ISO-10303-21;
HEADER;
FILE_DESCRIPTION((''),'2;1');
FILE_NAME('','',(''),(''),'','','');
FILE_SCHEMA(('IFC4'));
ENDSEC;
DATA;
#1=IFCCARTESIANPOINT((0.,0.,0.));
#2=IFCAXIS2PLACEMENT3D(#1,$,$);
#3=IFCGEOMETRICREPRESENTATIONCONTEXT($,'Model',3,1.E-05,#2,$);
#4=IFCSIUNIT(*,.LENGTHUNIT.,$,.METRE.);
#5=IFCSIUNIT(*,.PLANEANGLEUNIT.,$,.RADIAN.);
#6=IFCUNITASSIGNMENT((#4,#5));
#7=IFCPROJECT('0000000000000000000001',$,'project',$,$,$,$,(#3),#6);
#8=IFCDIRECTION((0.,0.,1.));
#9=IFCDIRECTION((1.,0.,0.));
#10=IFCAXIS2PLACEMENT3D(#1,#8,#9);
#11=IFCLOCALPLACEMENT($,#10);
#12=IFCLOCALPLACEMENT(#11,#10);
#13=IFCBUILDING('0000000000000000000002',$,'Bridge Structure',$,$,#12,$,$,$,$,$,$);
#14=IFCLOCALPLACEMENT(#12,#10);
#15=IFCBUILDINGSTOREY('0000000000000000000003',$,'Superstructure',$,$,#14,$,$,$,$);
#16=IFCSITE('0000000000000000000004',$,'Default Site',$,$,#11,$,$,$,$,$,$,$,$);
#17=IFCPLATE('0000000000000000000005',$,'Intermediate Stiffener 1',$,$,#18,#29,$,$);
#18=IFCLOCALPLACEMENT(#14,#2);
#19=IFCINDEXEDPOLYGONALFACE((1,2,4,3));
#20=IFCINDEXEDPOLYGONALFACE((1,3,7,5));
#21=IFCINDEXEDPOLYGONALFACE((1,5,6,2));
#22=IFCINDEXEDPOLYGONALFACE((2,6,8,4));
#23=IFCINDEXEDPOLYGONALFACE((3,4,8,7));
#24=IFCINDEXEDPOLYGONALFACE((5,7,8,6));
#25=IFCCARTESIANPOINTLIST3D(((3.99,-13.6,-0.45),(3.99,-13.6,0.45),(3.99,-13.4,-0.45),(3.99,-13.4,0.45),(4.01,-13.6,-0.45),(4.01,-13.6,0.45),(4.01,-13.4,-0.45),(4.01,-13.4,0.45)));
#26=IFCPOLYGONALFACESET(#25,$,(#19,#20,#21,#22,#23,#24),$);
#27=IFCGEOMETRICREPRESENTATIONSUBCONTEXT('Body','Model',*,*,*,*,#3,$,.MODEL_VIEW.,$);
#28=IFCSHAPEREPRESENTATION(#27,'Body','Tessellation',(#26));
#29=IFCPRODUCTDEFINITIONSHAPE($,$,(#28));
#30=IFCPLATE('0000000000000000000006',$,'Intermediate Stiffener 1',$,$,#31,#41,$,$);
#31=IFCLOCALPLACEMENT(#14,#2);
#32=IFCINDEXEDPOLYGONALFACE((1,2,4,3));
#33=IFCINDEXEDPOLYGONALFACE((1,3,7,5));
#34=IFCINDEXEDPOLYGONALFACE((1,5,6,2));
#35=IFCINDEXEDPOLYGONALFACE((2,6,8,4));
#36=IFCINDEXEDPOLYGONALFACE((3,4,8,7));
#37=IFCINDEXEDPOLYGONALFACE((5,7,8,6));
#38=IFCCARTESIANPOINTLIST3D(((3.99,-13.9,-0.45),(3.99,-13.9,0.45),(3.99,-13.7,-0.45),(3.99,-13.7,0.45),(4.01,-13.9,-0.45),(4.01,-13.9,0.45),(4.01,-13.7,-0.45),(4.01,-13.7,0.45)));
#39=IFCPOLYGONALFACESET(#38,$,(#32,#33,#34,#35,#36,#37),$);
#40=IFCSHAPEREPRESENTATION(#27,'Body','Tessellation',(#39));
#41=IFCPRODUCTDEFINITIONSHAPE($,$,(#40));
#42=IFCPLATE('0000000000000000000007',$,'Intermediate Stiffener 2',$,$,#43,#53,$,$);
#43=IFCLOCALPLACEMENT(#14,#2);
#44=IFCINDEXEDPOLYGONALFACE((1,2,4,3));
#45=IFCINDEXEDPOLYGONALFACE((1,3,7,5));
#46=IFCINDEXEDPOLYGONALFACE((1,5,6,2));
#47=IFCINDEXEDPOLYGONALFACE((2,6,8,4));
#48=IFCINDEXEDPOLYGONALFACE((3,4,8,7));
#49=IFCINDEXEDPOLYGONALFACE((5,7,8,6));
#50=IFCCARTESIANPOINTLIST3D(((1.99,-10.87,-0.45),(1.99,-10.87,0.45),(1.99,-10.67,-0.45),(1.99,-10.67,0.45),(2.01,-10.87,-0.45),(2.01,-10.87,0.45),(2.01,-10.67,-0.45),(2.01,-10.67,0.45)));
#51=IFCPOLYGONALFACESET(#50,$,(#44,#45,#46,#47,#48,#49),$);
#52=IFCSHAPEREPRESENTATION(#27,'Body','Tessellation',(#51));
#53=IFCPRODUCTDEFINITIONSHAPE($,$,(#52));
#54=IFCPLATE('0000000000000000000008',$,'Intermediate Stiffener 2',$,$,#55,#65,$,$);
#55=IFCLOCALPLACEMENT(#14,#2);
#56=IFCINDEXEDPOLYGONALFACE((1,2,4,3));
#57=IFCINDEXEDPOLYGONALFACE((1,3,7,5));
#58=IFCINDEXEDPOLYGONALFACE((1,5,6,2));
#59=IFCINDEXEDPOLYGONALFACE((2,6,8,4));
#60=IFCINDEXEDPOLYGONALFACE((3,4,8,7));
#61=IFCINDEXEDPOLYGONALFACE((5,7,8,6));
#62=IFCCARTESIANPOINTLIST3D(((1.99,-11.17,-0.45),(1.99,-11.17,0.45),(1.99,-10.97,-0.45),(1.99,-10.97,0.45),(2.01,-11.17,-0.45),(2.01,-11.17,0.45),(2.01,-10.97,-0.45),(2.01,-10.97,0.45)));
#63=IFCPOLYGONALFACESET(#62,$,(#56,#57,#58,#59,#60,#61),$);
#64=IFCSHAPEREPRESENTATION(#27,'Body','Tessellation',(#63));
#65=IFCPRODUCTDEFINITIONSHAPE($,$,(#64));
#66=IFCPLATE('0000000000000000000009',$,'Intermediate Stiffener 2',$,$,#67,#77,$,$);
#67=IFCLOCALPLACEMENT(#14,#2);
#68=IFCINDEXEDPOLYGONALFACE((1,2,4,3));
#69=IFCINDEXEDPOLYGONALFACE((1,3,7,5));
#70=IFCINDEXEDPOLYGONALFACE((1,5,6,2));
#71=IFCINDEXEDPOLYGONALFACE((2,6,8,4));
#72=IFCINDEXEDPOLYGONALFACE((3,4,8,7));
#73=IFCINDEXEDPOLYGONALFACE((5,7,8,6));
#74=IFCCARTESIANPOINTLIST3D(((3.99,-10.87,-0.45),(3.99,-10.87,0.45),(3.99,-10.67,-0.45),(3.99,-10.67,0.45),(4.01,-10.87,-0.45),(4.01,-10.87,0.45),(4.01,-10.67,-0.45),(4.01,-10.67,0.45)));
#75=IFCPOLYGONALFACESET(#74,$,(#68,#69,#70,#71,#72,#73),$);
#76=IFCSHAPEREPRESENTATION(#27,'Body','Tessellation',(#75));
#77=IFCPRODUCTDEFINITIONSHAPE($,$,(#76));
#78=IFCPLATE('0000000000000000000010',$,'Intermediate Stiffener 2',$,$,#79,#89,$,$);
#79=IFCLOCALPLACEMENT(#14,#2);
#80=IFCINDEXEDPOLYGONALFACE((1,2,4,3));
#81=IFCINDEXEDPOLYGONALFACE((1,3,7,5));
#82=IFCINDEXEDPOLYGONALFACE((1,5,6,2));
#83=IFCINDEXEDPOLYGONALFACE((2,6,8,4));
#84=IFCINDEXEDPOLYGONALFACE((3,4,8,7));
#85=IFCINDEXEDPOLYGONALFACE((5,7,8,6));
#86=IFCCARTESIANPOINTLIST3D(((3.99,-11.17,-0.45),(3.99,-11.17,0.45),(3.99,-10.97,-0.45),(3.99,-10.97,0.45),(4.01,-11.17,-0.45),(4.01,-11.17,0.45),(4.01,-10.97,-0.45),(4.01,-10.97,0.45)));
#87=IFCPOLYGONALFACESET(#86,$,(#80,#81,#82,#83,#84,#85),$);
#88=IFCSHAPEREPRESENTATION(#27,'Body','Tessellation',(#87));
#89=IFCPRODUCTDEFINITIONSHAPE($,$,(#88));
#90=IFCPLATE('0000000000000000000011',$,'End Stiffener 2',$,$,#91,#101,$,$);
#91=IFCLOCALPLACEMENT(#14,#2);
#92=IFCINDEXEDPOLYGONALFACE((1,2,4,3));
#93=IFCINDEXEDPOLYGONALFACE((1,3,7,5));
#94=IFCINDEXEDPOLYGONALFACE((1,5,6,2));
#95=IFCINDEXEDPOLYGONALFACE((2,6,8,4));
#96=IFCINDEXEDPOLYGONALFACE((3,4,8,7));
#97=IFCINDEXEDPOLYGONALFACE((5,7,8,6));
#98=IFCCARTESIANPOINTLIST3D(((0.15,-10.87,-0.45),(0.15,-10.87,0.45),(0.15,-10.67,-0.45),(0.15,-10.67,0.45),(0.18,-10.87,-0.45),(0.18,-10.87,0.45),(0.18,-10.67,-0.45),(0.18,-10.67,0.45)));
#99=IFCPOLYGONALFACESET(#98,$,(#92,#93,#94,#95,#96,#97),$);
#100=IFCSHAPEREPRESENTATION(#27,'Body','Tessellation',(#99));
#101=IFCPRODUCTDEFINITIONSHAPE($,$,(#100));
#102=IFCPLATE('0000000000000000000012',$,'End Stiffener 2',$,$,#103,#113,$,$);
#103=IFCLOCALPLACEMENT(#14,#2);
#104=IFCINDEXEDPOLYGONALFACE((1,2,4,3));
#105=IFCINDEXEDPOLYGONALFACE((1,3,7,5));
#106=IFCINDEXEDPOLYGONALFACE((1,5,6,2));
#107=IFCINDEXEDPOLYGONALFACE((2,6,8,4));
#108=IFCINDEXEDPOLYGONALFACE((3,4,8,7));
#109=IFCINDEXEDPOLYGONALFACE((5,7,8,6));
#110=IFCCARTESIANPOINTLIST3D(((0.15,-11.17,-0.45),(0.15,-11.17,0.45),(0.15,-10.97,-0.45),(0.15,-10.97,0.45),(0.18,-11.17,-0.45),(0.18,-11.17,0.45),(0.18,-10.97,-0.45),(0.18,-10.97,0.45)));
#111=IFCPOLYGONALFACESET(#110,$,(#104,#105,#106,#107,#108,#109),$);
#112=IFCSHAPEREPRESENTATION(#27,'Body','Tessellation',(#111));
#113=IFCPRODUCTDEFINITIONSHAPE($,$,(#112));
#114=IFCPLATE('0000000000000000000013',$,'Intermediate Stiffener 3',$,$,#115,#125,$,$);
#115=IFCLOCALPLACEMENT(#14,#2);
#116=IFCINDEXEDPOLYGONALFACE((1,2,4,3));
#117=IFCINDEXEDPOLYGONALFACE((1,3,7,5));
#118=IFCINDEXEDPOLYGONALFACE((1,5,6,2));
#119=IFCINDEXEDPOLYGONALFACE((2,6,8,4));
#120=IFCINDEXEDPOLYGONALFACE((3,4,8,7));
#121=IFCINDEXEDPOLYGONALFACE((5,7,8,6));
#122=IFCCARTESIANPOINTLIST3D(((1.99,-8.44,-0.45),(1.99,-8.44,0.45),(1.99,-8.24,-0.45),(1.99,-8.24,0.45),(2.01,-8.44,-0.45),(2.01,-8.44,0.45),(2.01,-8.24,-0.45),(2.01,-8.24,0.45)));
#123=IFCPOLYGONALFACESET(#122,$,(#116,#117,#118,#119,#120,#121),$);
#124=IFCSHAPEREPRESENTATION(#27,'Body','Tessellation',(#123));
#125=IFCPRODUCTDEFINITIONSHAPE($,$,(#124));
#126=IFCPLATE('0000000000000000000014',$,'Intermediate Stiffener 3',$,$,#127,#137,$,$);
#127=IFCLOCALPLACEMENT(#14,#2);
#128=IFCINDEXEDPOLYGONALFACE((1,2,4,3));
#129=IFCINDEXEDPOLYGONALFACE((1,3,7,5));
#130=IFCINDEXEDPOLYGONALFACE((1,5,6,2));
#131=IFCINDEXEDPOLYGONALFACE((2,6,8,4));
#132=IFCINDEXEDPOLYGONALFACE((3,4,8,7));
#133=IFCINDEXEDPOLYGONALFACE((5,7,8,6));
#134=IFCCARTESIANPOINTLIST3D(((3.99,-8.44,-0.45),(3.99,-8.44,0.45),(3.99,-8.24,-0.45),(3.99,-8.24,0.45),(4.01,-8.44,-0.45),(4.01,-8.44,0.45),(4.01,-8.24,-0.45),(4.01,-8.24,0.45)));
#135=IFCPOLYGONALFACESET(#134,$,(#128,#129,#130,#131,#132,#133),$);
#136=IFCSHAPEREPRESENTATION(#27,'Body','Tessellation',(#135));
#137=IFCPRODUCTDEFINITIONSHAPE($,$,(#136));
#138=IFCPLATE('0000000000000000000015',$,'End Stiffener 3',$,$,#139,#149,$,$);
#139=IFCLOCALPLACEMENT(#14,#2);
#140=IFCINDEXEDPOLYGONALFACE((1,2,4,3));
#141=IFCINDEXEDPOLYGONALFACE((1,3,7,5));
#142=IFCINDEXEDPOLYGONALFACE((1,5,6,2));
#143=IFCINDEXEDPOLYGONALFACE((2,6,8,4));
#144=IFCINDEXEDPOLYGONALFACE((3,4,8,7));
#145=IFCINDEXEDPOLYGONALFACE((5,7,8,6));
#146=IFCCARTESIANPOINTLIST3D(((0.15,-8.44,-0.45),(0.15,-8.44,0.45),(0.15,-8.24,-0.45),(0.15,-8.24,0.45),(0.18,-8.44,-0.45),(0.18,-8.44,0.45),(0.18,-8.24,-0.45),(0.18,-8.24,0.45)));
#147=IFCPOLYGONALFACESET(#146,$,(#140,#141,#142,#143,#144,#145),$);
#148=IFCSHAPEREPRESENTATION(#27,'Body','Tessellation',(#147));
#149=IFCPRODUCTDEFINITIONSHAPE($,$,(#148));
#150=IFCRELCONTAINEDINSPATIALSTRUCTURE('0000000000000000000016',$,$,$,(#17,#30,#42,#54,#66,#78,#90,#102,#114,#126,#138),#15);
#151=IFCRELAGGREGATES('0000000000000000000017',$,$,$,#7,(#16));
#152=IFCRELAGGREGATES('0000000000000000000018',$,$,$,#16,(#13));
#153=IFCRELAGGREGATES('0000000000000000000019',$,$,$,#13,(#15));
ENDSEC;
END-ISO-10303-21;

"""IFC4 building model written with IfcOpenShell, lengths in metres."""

from ifc_helpers import new_model, si_unit, frame, origin, origin_with_axes, origin_2d_with_axis, place, context, subcontext, project, spatial, rectangle, extrude, element, save


model = new_model("IFC4")

# Units and contexts
model_context = context("Model", 3, precision=1e-05, world=origin())
body_context = subcontext(model_context, "Body", "Model", "MODEL_VIEW")
ifc_project = project(units=[si_unit("LENGTHUNIT", "METRE"), si_unit("PLANEANGLEUNIT", "RADIAN")], contexts=[model_context])

# Site, building, storey
site_placement = place(None, origin_with_axes())
site = spatial("IfcSite", under=ifc_project, at=site_placement, Name="Default Site")
building_placement = place(site_placement, origin_with_axes())
building = spatial("IfcBuilding", under=site, at=building_placement, Name="Bridge Structure")
storey_placement = place(building_placement, origin_with_axes())
storey = spatial("IfcBuildingStorey", under=building, at=storey_placement, Name="Superstructure")

# Plates
for number, where, z_axis, x_axis, name in (
    (1, (4.0, -13.5, -0.45), (0.0, 0.0, 1.0), (1.0, 0.0, 0.0), "Intermediate Stiffener 1"),
    (2, (4.0, -13.8, -0.45), (0.0, 0.0, 1.0), (1.0, 0.0, 0.0), "Intermediate Stiffener 1"),
    (3, (2.0, -10.77, -0.45), (0.0, 0.0, 1.0), (1.0, 0.0, 0.0), "Intermediate Stiffener 2"),
    (4, (2.0, -11.07, -0.45), (0.0, 0.0, 1.0), (1.0, 0.0, 0.0), "Intermediate Stiffener 2"),
    (5, (4.0, -10.77, -0.45), (0.0, 0.0, 1.0), (1.0, 0.0, 0.0), "Intermediate Stiffener 2"),
    (6, (4.0, -11.07, -0.45), (0.0, 0.0, 1.0), (1.0, 0.0, 0.0), "Intermediate Stiffener 2"),
):
    element("IfcPlate", number, at=place(storey_placement, frame(where, z_axis=z_axis, x_axis=x_axis)), inside=storey, Name=name, context=body_context, shape_type="SweptSolid", body=[
        extrude(rectangle(XDim=0.02, YDim=0.2, at=origin_2d_with_axis()), origin_with_axes(), (0.0, 0.0, 1.0), 0.9),
    ])
for number, where, z_axis, x_axis, name in (
    (7, (0.165, -10.77, -0.45), (0.0, 0.0, 1.0), (1.0, 0.0, 0.0), "End Stiffener 2"),
    (8, (0.165, -11.07, -0.45), (0.0, 0.0, 1.0), (1.0, 0.0, 0.0), "End Stiffener 2"),
):
    element("IfcPlate", number, at=place(storey_placement, frame(where, z_axis=z_axis, x_axis=x_axis)), inside=storey, Name=name, context=body_context, shape_type="SweptSolid", body=[
        extrude(rectangle(XDim=0.03, YDim=0.2, at=origin_2d_with_axis()), origin_with_axes(), (0.0, 0.0, 1.0), 0.9),
    ])
for number, where, z_axis, x_axis, name in (
    (9, (2.0, -8.34, -0.45), (0.0, 0.0, 1.0), (1.0, 0.0, 0.0), "Intermediate Stiffener 3"),
    (10, (4.0, -8.34, -0.45), (0.0, 0.0, 1.0), (1.0, 0.0, 0.0), "Intermediate Stiffener 3"),
):
    element("IfcPlate", number, at=place(storey_placement, frame(where, z_axis=z_axis, x_axis=x_axis)), inside=storey, Name=name, context=body_context, shape_type="SweptSolid", body=[
        extrude(rectangle(XDim=0.02, YDim=0.2, at=origin_2d_with_axis()), origin_with_axes(), (0.0, 0.0, 1.0), 0.9),
    ])
plate_placement = place(storey_placement, frame((0.165, -8.34, -0.45), z_axis=(0.0, 0.0, 1.0), x_axis=(1.0, 0.0, 0.0)))
element("IfcPlate", 11, at=plate_placement, inside=storey, Name="End Stiffener 3", context=body_context, shape_type="SweptSolid", body=[
    extrude(rectangle(XDim=0.03, YDim=0.2, at=origin_2d_with_axis()), origin_with_axes(), (0.0, 0.0, 1.0), 0.9),
])

save(model, "model.ifc")
